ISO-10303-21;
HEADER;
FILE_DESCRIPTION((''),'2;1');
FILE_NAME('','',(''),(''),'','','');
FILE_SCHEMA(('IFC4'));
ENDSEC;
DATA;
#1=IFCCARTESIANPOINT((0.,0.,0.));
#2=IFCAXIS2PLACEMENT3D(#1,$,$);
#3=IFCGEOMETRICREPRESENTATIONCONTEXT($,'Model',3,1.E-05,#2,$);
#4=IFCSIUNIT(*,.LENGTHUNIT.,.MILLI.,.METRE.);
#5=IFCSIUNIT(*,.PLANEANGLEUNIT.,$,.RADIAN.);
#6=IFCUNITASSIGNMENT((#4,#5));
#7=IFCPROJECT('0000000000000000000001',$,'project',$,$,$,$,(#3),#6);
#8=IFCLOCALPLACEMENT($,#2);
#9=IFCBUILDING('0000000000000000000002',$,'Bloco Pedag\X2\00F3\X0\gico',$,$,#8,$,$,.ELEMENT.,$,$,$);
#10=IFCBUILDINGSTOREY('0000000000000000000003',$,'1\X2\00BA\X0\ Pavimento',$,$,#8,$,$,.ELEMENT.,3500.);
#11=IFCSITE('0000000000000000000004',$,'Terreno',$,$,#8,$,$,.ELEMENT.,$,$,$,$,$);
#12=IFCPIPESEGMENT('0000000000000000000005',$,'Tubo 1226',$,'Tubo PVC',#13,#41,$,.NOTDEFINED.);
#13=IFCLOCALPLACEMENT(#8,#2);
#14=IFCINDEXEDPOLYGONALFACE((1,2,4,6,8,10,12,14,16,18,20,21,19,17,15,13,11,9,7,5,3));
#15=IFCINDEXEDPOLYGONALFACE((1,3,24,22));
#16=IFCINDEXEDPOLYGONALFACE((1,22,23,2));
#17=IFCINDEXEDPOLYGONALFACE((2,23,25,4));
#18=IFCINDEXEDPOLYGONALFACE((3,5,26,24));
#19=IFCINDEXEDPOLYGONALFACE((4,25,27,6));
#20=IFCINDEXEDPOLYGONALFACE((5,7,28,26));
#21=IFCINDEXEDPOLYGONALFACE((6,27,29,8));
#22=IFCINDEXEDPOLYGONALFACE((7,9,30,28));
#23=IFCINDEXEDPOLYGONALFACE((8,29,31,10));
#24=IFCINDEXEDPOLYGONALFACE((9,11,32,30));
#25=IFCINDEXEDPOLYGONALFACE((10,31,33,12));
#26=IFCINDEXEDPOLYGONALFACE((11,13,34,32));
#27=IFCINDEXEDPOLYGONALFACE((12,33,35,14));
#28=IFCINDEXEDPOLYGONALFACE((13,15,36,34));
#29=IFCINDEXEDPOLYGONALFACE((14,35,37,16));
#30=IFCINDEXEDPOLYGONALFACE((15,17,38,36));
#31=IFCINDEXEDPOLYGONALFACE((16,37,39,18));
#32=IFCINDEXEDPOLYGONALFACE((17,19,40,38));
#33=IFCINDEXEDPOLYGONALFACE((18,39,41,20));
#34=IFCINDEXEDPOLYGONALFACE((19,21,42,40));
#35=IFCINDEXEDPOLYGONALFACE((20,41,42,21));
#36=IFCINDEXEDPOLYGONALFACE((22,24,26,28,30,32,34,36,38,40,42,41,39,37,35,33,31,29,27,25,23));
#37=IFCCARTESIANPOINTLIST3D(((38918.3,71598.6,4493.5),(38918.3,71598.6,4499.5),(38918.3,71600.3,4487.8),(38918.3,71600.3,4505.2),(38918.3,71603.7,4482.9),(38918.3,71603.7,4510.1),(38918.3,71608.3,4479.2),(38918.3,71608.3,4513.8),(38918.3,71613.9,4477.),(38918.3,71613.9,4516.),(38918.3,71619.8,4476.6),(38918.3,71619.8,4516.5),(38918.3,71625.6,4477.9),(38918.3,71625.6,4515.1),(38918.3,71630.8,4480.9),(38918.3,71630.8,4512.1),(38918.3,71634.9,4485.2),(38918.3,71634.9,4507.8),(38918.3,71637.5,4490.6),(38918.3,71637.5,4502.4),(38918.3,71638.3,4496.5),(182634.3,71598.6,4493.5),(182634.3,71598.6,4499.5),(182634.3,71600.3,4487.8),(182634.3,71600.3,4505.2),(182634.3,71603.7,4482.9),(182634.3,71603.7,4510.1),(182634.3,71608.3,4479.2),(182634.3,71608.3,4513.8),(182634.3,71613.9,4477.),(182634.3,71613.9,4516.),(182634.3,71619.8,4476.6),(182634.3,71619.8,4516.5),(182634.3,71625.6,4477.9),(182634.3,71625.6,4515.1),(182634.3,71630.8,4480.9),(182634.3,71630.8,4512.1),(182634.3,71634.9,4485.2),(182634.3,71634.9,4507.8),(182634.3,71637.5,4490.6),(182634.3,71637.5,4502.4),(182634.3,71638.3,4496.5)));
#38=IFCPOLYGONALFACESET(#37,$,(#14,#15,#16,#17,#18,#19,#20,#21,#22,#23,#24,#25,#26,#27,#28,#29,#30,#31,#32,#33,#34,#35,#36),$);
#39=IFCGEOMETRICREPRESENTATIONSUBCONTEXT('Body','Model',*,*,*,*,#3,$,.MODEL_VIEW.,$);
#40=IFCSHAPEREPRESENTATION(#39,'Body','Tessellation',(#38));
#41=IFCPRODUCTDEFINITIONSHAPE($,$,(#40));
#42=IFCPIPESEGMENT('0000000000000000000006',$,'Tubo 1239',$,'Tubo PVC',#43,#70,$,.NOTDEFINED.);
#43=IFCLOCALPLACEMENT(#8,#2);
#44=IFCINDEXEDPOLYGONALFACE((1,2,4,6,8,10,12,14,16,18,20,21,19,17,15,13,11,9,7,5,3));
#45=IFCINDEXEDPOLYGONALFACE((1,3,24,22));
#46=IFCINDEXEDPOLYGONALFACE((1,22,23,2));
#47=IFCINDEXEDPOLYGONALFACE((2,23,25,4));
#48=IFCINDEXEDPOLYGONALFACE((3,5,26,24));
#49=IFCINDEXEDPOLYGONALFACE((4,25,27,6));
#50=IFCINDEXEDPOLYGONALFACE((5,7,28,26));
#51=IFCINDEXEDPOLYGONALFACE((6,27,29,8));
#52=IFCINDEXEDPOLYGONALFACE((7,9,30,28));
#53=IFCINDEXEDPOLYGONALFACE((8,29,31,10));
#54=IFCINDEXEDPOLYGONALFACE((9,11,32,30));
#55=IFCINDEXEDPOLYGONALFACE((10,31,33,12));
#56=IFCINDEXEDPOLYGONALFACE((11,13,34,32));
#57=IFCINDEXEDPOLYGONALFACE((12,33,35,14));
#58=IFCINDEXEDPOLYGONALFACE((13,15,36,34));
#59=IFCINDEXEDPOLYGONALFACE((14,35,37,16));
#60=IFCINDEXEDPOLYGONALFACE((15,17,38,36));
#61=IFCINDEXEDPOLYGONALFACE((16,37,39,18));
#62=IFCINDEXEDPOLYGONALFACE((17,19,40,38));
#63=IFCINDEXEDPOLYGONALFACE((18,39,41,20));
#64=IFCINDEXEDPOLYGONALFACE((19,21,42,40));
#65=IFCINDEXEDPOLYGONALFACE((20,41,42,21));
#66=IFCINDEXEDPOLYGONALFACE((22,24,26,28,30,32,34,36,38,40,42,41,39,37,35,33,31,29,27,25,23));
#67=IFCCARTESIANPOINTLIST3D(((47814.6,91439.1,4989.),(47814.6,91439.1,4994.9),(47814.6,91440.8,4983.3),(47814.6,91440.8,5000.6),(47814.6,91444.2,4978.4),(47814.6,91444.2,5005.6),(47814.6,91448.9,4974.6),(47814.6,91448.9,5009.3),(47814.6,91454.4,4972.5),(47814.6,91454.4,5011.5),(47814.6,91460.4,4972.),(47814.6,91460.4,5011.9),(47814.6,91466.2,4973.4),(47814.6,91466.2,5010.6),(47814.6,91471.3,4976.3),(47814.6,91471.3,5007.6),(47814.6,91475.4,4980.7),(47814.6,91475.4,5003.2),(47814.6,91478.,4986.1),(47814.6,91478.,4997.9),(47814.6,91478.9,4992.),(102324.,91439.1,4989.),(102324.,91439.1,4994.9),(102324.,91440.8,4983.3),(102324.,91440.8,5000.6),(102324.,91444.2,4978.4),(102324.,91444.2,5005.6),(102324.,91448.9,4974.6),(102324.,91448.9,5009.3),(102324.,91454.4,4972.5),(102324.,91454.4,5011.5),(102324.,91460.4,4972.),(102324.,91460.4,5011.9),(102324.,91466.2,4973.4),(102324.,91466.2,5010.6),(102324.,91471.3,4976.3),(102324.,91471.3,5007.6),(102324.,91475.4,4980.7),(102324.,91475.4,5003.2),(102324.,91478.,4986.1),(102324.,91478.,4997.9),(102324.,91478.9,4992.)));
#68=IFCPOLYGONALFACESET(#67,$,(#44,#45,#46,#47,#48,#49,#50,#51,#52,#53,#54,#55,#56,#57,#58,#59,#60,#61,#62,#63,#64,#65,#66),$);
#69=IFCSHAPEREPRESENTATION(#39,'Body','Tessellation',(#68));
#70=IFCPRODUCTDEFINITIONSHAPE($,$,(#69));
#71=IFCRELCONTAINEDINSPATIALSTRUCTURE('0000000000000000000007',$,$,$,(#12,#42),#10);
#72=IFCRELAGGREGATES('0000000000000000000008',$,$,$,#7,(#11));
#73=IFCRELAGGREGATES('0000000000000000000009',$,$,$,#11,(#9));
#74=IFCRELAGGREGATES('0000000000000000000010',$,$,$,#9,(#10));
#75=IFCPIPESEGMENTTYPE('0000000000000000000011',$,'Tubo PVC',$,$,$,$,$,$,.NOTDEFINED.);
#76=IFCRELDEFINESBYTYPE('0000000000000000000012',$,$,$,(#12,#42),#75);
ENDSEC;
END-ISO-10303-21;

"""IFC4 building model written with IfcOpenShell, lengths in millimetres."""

from ifc_helpers import new_model, si_unit, frame, origin, origin_2d, place, context, subcontext, project, spatial, circle, extrude, type_object, element, save


model = new_model("IFC4")

# Units and contexts
model_context = context("Model", 3, precision=1e-05, world=origin())
body_context = subcontext(model_context, "Body", "Model", "MODEL_VIEW")
ifc_project = project(units=[si_unit("LENGTHUNIT", "METRE", prefix="MILLI"), si_unit("PLANEANGLEUNIT", "RADIAN")], contexts=[model_context])

# Site, building, storey
placement = place(None, origin())
site = spatial("IfcSite", under=ifc_project, at=placement, Name="Terreno", CompositionType="ELEMENT")
building = spatial("IfcBuilding", under=site, at=placement, Name="Bloco Pedagógico", CompositionType="ELEMENT")
storey = spatial("IfcBuildingStorey", under=building, at=placement, Name="1º Pavimento", CompositionType="ELEMENT", Elevation=3500.0)

# Pipe segments
pipe_segment_type = type_object("IfcPipeSegmentType", Name="Tubo PVC", PredefinedType="NOTDEFINED")
pipe_segment_1_placement = place(None, frame((38918.3, 71618.3, 4496.5), z_axis=(1.0, 0.0, 0.0), x_axis=(0.0, 1.0, 0.0)))
element("IfcPipeSegment", 1, at=pipe_segment_1_placement, inside=storey, type_object=pipe_segment_type, Name="Tubo 1226", ObjectType="Tubo PVC", PredefinedType="NOTDEFINED", context=body_context, shape_type="SweptSolid", body=[
    extrude(circle(Radius=20.0, at=origin_2d()), None, (0.0, 0.0, 1.0), 143716.0),
])
pipe_segment_2_placement = place(None, frame((47814.6, 91458.9, 4992.0), z_axis=(1.0, 0.0, 0.0), x_axis=(0.0, 1.0, 0.0)))
element("IfcPipeSegment", 2, at=pipe_segment_2_placement, inside=storey, type_object=pipe_segment_type, Name="Tubo 1239", ObjectType="Tubo PVC", PredefinedType="NOTDEFINED", context=body_context, shape_type="SweptSolid", body=[
    extrude(circle(Radius=20.0, at=origin_2d()), None, (0.0, 0.0, 1.0), 54509.4),
])

save(model, "model.ifc")
